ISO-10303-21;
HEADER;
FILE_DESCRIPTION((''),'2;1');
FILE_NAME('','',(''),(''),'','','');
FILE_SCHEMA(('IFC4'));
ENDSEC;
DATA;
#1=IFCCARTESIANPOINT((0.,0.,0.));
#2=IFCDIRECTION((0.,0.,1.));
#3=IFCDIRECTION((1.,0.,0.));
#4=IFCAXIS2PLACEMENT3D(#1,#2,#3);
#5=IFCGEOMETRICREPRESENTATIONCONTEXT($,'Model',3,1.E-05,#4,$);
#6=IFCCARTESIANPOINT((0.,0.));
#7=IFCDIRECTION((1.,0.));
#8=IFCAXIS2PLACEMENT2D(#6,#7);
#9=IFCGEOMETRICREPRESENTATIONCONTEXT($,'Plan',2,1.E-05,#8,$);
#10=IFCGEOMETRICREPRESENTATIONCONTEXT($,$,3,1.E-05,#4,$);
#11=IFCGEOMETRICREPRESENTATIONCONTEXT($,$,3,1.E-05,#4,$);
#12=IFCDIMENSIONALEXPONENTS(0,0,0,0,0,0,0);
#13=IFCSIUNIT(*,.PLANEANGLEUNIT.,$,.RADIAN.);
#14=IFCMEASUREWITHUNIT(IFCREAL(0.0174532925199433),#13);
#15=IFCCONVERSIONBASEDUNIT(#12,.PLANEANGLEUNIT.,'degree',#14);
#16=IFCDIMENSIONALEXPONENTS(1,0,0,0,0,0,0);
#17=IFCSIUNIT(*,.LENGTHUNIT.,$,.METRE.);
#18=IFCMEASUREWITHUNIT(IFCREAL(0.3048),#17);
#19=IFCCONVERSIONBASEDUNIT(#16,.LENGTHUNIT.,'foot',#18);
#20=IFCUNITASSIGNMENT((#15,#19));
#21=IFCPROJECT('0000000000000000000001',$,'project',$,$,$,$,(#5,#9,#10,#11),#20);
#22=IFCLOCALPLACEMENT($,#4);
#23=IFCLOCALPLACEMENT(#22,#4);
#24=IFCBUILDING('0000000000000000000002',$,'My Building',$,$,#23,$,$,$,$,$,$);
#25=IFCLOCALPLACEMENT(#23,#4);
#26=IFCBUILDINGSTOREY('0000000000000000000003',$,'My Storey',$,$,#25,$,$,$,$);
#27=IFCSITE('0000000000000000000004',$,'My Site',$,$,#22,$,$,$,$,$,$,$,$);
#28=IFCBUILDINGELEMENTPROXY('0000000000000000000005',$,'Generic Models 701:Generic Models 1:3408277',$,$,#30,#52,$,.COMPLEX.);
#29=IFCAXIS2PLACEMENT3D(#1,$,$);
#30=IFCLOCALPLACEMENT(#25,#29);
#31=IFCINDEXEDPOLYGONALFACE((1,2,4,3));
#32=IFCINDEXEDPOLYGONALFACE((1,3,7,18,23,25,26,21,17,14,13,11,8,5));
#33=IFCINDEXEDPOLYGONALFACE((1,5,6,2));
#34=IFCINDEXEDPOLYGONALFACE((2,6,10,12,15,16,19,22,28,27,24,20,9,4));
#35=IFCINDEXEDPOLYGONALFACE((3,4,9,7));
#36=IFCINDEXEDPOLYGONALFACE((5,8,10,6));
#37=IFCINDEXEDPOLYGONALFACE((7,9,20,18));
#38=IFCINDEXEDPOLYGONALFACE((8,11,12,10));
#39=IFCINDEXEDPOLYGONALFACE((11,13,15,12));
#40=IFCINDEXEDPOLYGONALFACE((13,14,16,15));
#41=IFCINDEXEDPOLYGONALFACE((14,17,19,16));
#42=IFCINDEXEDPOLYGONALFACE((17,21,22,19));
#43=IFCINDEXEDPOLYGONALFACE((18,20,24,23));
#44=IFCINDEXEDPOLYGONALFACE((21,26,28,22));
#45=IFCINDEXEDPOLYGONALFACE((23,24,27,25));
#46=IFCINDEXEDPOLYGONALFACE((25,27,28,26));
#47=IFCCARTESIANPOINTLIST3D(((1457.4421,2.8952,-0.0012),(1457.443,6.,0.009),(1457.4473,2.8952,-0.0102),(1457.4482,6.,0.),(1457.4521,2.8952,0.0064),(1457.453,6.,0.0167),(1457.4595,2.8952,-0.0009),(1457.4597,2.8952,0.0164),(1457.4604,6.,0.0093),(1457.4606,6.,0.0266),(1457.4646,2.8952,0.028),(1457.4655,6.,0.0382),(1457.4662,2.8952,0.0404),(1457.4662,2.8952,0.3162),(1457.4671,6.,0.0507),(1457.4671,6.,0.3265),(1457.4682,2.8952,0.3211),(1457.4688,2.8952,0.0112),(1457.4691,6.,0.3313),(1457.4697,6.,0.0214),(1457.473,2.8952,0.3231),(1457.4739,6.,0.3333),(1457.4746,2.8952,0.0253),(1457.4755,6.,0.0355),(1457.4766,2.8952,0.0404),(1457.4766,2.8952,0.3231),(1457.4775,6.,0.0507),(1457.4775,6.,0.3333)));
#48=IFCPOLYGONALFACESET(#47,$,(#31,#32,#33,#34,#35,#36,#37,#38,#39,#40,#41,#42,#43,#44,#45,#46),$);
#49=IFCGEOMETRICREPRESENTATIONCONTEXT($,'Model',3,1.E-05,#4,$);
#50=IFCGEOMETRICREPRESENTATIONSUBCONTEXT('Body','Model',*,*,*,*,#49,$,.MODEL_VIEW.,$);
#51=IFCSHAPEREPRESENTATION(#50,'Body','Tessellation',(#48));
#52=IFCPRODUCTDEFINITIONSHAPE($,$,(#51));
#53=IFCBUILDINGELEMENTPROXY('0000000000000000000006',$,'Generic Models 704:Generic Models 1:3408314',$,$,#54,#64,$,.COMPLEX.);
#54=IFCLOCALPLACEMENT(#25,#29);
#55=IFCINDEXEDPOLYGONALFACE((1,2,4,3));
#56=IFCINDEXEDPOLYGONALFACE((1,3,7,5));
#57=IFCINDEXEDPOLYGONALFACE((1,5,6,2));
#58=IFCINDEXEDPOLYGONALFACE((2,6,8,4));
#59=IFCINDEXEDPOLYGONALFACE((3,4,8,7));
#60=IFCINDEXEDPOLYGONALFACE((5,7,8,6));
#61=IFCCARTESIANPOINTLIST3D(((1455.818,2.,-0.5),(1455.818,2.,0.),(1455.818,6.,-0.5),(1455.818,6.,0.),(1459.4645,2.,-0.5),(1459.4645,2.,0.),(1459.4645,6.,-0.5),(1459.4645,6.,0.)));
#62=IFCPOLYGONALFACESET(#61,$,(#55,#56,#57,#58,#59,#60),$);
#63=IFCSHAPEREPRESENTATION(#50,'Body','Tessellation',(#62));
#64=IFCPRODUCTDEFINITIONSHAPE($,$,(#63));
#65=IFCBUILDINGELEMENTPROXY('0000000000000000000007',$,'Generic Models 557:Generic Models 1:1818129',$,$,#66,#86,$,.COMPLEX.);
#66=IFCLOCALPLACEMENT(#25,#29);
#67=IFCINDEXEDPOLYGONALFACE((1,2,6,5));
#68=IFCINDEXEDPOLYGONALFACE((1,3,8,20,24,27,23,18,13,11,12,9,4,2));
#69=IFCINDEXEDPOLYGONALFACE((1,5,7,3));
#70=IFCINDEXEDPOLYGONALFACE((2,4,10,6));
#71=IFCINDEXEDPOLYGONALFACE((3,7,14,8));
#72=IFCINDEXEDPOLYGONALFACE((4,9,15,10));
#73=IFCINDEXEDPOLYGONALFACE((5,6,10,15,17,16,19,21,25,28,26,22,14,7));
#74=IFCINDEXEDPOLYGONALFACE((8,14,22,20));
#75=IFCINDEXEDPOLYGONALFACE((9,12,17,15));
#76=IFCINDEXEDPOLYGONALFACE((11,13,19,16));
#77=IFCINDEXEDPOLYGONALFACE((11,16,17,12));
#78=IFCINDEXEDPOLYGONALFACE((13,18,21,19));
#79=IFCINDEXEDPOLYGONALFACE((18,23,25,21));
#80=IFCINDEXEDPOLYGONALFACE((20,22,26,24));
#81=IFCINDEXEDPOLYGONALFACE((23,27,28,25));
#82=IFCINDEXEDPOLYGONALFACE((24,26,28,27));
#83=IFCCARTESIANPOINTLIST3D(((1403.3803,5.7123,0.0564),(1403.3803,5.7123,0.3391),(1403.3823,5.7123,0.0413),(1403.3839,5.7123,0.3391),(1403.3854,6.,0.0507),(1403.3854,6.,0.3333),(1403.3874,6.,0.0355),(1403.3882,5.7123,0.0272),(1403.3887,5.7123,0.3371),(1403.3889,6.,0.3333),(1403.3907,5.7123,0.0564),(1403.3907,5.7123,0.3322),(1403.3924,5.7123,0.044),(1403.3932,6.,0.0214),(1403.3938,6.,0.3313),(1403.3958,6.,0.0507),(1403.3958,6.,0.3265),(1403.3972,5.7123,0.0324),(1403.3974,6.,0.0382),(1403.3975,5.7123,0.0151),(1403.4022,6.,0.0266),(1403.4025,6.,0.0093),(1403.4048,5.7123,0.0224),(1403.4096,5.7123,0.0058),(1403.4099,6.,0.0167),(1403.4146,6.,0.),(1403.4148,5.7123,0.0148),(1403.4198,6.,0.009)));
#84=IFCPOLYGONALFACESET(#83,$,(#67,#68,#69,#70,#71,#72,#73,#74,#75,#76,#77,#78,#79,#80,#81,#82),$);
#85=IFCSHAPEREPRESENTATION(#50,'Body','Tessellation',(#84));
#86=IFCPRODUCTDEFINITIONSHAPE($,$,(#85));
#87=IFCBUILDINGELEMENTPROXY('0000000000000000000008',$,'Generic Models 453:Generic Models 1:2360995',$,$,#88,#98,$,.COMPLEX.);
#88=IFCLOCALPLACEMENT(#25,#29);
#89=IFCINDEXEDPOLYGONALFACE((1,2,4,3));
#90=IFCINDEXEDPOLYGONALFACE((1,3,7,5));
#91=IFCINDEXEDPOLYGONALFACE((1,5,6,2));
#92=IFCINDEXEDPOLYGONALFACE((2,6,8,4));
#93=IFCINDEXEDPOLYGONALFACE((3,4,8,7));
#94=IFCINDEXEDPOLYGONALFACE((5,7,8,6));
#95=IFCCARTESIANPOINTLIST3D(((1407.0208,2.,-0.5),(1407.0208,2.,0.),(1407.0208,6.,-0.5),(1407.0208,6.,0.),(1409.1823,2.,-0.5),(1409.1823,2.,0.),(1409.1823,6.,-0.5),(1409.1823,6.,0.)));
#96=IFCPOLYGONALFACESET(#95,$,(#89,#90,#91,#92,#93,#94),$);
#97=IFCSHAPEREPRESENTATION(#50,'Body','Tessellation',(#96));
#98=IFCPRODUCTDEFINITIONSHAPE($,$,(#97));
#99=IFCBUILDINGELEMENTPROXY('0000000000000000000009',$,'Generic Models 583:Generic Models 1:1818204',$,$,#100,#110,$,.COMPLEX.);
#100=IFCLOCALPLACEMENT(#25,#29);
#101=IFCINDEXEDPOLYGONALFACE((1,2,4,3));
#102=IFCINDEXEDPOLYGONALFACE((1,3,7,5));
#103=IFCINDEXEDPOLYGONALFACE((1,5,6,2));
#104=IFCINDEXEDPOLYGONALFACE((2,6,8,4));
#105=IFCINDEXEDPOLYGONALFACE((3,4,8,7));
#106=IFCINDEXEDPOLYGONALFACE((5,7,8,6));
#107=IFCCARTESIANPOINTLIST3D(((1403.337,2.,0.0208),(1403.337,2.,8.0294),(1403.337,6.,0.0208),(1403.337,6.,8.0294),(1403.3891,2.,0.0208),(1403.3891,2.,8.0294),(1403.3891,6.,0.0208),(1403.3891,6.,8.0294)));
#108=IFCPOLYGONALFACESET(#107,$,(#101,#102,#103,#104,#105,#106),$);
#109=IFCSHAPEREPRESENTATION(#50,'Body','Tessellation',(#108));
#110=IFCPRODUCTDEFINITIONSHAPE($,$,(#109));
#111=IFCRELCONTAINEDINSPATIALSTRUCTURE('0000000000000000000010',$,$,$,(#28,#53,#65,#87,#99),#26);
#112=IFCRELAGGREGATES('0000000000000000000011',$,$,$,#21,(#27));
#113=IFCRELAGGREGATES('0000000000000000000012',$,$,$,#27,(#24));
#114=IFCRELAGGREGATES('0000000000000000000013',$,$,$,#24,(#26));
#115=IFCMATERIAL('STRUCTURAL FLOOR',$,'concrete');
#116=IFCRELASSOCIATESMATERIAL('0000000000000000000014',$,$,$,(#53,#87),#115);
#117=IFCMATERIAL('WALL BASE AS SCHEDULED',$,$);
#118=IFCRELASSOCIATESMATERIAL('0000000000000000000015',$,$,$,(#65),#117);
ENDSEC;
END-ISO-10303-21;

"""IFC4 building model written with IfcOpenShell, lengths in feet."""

from ifc_helpers import new_model, entity, si_unit, converted_unit, frame, origin_with_axes, origin_2d_with_axis, place, context, subcontext, project, spatial, polyline, line, indexed_curve, outline, extrude, material, element, save


model = new_model("IFC4")

# Units and contexts
model_context_1 = context("Model", 3, precision=1e-05, world=origin_with_axes())
plan_context = context("Plan", 2, precision=1e-05, world=origin_2d_with_axis())
model_context_2 = context("Model", 3, precision=1e-05, world=origin_with_axes())
context_of_model_1 = context(None, 3, precision=1e-05, world=origin_with_axes())
context_of_model_2 = context(None, 3, precision=1e-05, world=origin_with_axes())
body_context = subcontext(model_context_2, "Body", "Model", "MODEL_VIEW")
ifc_project = project(units=[converted_unit("PLANEANGLEUNIT", "degree", entity("IfcReal", 0.0174532925199433), si_unit("PLANEANGLEUNIT", "RADIAN"), dimensions=[0, 0, 0, 0, 0, 0, 0]), converted_unit("LENGTHUNIT", "foot", entity("IfcReal", 0.3048), si_unit("LENGTHUNIT", "METRE"), dimensions=[1, 0, 0, 0, 0, 0, 0])], contexts=[model_context_1, plan_context, context_of_model_1, context_of_model_2])

# Site, building, storey
site_placement = place(None, origin_with_axes())
site = spatial("IfcSite", under=ifc_project, at=site_placement, Name="My Site")
building_placement = place(site_placement, origin_with_axes())
building = spatial("IfcBuilding", under=site, at=building_placement, Name="My Building")
storey_placement = place(building_placement, origin_with_axes())
storey = spatial("IfcBuildingStorey", under=building, at=storey_placement, Name="My Storey")

# Building element proxies
ifc_material_1 = material(Name="WALL BASE AS SCHEDULED")
ifc_material_2 = material(Name="STRUCTURAL FLOOR", Category="concrete")
proxy_1_placement = place(storey_placement, frame((1457.443, 6.0, 0.0), z_axis=(0.0, -1.0, 0.0), x_axis=(0.0, 0.0, 1.0)))
element("IfcBuildingElementProxy", 1, at=proxy_1_placement, inside=storey, Name="Generic Models 701:Generic Models 1:3408277", PredefinedType="COMPLEX", context=body_context, shape_type="SweptSolid", body=[
    extrude(outline(polyline([(-0.0624, 0.0022), (0.2134, 0.0022), (0.2183, 0.0042), (0.2203, 0.0091), (0.2203, 0.0126), (-0.0624, 0.0126), (-0.0775, 0.0106), (-0.0916, 0.0048), (-0.1037, -0.0045), (-0.113, -0.0166), (-0.104, -0.0218), (-0.0964, -0.0119), (-0.0864, -0.0042), (-0.0748, 0.0006), (-0.0624, 0.0022)])), frame((0.113, -0.0218, 0.0), z_axis=(0.0, 0.0, -1.0), x_axis=(1.0, 0.0, 0.0)), (-0.003299, -0.000291, -0.999995), 3.1048),
])
proxy_2_placement = place(storey_placement, frame((1455.818, 6.0, -0.5), z_axis=(0.0, -1.0, 0.0), x_axis=(0.0, 0.0, 1.0)))
element("IfcBuildingElementProxy", 2, at=proxy_2_placement, inside=storey, material=ifc_material_2, Name="Generic Models 704:Generic Models 1:3408314", PredefinedType="COMPLEX", context=body_context, shape_type="SweptSolid", body=[
    extrude(outline(polyline([(-0.25, -1.8232), (0.25, -1.8232), (0.25, 1.8232), (-0.25, 1.8232), (-0.25, -1.8232)])), frame((0.25, -1.8232, 0.0), z_axis=(0.0, 0.0, -1.0), x_axis=(1.0, 0.0, 0.0)), (0.0, 0.0, -1.0), 4.0),
])
proxy_3_placement = place(storey_placement, frame((1403.3854, 6.0, 0.0), z_axis=(0.0, -1.0, 0.0), x_axis=(0.0, 0.0, 1.0)))
element("IfcBuildingElementProxy", 3, at=proxy_3_placement, inside=storey, material=ifc_material_1, Name="Generic Models 557:Generic Models 1:1818129", PredefinedType="COMPLEX", context=body_context, shape_type="SweptSolid", body=[
    extrude(outline(polyline([(0.1038, 0.0), (0.0913, 0.0088), (0.077, 0.014), (0.0618, 0.0153), (-0.2206, 0.0031), (-0.2205, -0.0005), (-0.2183, -0.0052), (-0.2133, -0.007), (0.0622, 0.0049), (0.0747, 0.0038), (0.0865, -0.0005), (0.0968, -0.0077), (0.1049, -0.0173), (0.1137, -0.0117), (0.1038, 0.0)])), frame((0.113, -0.0126, 0.0), z_axis=(0.0, 0.0, -1.0), x_axis=(-0.999059, -0.043362, 0.0)), (-0.020742, 0.016656, -0.999646), 0.2878),
])
proxy_4_placement = place(storey_placement, frame((1407.0208, 6.0, -0.5), z_axis=(0.0, -1.0, 0.0), x_axis=(0.0, 0.0, 1.0)))
element("IfcBuildingElementProxy", 4, at=proxy_4_placement, inside=storey, material=ifc_material_2, Name="Generic Models 453:Generic Models 1:2360995", PredefinedType="COMPLEX", context=body_context, shape_type="SweptSolid", body=[
    extrude(outline(polyline([(-0.25, -1.0807), (0.25, -1.0807), (0.25, 1.0807), (-0.25, 1.0807), (-0.25, -1.0807)])), frame((0.25, -1.0807, 0.0), z_axis=(0.0, 0.0, -1.0), x_axis=(1.0, 0.0, 0.0)), (0.0, 0.0, -1.0), 4.0),
])
proxy_5_placement = place(storey_placement, frame((1403.337, 6.0, 0.0208), z_axis=(0.0, -1.0, 0.0), x_axis=(0.0, 0.0, 1.0)))
element("IfcBuildingElementProxy", 5, at=proxy_5_placement, inside=storey, Name="Generic Models 583:Generic Models 1:1818204", PredefinedType="COMPLEX", context=body_context, shape_type="SweptSolid", body=[
    extrude(outline(indexed_curve([(4.0043, 0.026), (4.0043, -0.026), (-4.0043, -0.026), (-4.0043, 0.026)], segments=[line(4, 1), line(1, 2), line(2, 3), line(3, 4)], self_intersect=False)), frame((4.0043, -0.026, 0.0), z_axis=(0.0, 0.0, -1.0), x_axis=(-1.0, 0.0, 0.0)), (0.0, 0.0, -1.0), 4.0),
])

save(model, "model.ifc")
